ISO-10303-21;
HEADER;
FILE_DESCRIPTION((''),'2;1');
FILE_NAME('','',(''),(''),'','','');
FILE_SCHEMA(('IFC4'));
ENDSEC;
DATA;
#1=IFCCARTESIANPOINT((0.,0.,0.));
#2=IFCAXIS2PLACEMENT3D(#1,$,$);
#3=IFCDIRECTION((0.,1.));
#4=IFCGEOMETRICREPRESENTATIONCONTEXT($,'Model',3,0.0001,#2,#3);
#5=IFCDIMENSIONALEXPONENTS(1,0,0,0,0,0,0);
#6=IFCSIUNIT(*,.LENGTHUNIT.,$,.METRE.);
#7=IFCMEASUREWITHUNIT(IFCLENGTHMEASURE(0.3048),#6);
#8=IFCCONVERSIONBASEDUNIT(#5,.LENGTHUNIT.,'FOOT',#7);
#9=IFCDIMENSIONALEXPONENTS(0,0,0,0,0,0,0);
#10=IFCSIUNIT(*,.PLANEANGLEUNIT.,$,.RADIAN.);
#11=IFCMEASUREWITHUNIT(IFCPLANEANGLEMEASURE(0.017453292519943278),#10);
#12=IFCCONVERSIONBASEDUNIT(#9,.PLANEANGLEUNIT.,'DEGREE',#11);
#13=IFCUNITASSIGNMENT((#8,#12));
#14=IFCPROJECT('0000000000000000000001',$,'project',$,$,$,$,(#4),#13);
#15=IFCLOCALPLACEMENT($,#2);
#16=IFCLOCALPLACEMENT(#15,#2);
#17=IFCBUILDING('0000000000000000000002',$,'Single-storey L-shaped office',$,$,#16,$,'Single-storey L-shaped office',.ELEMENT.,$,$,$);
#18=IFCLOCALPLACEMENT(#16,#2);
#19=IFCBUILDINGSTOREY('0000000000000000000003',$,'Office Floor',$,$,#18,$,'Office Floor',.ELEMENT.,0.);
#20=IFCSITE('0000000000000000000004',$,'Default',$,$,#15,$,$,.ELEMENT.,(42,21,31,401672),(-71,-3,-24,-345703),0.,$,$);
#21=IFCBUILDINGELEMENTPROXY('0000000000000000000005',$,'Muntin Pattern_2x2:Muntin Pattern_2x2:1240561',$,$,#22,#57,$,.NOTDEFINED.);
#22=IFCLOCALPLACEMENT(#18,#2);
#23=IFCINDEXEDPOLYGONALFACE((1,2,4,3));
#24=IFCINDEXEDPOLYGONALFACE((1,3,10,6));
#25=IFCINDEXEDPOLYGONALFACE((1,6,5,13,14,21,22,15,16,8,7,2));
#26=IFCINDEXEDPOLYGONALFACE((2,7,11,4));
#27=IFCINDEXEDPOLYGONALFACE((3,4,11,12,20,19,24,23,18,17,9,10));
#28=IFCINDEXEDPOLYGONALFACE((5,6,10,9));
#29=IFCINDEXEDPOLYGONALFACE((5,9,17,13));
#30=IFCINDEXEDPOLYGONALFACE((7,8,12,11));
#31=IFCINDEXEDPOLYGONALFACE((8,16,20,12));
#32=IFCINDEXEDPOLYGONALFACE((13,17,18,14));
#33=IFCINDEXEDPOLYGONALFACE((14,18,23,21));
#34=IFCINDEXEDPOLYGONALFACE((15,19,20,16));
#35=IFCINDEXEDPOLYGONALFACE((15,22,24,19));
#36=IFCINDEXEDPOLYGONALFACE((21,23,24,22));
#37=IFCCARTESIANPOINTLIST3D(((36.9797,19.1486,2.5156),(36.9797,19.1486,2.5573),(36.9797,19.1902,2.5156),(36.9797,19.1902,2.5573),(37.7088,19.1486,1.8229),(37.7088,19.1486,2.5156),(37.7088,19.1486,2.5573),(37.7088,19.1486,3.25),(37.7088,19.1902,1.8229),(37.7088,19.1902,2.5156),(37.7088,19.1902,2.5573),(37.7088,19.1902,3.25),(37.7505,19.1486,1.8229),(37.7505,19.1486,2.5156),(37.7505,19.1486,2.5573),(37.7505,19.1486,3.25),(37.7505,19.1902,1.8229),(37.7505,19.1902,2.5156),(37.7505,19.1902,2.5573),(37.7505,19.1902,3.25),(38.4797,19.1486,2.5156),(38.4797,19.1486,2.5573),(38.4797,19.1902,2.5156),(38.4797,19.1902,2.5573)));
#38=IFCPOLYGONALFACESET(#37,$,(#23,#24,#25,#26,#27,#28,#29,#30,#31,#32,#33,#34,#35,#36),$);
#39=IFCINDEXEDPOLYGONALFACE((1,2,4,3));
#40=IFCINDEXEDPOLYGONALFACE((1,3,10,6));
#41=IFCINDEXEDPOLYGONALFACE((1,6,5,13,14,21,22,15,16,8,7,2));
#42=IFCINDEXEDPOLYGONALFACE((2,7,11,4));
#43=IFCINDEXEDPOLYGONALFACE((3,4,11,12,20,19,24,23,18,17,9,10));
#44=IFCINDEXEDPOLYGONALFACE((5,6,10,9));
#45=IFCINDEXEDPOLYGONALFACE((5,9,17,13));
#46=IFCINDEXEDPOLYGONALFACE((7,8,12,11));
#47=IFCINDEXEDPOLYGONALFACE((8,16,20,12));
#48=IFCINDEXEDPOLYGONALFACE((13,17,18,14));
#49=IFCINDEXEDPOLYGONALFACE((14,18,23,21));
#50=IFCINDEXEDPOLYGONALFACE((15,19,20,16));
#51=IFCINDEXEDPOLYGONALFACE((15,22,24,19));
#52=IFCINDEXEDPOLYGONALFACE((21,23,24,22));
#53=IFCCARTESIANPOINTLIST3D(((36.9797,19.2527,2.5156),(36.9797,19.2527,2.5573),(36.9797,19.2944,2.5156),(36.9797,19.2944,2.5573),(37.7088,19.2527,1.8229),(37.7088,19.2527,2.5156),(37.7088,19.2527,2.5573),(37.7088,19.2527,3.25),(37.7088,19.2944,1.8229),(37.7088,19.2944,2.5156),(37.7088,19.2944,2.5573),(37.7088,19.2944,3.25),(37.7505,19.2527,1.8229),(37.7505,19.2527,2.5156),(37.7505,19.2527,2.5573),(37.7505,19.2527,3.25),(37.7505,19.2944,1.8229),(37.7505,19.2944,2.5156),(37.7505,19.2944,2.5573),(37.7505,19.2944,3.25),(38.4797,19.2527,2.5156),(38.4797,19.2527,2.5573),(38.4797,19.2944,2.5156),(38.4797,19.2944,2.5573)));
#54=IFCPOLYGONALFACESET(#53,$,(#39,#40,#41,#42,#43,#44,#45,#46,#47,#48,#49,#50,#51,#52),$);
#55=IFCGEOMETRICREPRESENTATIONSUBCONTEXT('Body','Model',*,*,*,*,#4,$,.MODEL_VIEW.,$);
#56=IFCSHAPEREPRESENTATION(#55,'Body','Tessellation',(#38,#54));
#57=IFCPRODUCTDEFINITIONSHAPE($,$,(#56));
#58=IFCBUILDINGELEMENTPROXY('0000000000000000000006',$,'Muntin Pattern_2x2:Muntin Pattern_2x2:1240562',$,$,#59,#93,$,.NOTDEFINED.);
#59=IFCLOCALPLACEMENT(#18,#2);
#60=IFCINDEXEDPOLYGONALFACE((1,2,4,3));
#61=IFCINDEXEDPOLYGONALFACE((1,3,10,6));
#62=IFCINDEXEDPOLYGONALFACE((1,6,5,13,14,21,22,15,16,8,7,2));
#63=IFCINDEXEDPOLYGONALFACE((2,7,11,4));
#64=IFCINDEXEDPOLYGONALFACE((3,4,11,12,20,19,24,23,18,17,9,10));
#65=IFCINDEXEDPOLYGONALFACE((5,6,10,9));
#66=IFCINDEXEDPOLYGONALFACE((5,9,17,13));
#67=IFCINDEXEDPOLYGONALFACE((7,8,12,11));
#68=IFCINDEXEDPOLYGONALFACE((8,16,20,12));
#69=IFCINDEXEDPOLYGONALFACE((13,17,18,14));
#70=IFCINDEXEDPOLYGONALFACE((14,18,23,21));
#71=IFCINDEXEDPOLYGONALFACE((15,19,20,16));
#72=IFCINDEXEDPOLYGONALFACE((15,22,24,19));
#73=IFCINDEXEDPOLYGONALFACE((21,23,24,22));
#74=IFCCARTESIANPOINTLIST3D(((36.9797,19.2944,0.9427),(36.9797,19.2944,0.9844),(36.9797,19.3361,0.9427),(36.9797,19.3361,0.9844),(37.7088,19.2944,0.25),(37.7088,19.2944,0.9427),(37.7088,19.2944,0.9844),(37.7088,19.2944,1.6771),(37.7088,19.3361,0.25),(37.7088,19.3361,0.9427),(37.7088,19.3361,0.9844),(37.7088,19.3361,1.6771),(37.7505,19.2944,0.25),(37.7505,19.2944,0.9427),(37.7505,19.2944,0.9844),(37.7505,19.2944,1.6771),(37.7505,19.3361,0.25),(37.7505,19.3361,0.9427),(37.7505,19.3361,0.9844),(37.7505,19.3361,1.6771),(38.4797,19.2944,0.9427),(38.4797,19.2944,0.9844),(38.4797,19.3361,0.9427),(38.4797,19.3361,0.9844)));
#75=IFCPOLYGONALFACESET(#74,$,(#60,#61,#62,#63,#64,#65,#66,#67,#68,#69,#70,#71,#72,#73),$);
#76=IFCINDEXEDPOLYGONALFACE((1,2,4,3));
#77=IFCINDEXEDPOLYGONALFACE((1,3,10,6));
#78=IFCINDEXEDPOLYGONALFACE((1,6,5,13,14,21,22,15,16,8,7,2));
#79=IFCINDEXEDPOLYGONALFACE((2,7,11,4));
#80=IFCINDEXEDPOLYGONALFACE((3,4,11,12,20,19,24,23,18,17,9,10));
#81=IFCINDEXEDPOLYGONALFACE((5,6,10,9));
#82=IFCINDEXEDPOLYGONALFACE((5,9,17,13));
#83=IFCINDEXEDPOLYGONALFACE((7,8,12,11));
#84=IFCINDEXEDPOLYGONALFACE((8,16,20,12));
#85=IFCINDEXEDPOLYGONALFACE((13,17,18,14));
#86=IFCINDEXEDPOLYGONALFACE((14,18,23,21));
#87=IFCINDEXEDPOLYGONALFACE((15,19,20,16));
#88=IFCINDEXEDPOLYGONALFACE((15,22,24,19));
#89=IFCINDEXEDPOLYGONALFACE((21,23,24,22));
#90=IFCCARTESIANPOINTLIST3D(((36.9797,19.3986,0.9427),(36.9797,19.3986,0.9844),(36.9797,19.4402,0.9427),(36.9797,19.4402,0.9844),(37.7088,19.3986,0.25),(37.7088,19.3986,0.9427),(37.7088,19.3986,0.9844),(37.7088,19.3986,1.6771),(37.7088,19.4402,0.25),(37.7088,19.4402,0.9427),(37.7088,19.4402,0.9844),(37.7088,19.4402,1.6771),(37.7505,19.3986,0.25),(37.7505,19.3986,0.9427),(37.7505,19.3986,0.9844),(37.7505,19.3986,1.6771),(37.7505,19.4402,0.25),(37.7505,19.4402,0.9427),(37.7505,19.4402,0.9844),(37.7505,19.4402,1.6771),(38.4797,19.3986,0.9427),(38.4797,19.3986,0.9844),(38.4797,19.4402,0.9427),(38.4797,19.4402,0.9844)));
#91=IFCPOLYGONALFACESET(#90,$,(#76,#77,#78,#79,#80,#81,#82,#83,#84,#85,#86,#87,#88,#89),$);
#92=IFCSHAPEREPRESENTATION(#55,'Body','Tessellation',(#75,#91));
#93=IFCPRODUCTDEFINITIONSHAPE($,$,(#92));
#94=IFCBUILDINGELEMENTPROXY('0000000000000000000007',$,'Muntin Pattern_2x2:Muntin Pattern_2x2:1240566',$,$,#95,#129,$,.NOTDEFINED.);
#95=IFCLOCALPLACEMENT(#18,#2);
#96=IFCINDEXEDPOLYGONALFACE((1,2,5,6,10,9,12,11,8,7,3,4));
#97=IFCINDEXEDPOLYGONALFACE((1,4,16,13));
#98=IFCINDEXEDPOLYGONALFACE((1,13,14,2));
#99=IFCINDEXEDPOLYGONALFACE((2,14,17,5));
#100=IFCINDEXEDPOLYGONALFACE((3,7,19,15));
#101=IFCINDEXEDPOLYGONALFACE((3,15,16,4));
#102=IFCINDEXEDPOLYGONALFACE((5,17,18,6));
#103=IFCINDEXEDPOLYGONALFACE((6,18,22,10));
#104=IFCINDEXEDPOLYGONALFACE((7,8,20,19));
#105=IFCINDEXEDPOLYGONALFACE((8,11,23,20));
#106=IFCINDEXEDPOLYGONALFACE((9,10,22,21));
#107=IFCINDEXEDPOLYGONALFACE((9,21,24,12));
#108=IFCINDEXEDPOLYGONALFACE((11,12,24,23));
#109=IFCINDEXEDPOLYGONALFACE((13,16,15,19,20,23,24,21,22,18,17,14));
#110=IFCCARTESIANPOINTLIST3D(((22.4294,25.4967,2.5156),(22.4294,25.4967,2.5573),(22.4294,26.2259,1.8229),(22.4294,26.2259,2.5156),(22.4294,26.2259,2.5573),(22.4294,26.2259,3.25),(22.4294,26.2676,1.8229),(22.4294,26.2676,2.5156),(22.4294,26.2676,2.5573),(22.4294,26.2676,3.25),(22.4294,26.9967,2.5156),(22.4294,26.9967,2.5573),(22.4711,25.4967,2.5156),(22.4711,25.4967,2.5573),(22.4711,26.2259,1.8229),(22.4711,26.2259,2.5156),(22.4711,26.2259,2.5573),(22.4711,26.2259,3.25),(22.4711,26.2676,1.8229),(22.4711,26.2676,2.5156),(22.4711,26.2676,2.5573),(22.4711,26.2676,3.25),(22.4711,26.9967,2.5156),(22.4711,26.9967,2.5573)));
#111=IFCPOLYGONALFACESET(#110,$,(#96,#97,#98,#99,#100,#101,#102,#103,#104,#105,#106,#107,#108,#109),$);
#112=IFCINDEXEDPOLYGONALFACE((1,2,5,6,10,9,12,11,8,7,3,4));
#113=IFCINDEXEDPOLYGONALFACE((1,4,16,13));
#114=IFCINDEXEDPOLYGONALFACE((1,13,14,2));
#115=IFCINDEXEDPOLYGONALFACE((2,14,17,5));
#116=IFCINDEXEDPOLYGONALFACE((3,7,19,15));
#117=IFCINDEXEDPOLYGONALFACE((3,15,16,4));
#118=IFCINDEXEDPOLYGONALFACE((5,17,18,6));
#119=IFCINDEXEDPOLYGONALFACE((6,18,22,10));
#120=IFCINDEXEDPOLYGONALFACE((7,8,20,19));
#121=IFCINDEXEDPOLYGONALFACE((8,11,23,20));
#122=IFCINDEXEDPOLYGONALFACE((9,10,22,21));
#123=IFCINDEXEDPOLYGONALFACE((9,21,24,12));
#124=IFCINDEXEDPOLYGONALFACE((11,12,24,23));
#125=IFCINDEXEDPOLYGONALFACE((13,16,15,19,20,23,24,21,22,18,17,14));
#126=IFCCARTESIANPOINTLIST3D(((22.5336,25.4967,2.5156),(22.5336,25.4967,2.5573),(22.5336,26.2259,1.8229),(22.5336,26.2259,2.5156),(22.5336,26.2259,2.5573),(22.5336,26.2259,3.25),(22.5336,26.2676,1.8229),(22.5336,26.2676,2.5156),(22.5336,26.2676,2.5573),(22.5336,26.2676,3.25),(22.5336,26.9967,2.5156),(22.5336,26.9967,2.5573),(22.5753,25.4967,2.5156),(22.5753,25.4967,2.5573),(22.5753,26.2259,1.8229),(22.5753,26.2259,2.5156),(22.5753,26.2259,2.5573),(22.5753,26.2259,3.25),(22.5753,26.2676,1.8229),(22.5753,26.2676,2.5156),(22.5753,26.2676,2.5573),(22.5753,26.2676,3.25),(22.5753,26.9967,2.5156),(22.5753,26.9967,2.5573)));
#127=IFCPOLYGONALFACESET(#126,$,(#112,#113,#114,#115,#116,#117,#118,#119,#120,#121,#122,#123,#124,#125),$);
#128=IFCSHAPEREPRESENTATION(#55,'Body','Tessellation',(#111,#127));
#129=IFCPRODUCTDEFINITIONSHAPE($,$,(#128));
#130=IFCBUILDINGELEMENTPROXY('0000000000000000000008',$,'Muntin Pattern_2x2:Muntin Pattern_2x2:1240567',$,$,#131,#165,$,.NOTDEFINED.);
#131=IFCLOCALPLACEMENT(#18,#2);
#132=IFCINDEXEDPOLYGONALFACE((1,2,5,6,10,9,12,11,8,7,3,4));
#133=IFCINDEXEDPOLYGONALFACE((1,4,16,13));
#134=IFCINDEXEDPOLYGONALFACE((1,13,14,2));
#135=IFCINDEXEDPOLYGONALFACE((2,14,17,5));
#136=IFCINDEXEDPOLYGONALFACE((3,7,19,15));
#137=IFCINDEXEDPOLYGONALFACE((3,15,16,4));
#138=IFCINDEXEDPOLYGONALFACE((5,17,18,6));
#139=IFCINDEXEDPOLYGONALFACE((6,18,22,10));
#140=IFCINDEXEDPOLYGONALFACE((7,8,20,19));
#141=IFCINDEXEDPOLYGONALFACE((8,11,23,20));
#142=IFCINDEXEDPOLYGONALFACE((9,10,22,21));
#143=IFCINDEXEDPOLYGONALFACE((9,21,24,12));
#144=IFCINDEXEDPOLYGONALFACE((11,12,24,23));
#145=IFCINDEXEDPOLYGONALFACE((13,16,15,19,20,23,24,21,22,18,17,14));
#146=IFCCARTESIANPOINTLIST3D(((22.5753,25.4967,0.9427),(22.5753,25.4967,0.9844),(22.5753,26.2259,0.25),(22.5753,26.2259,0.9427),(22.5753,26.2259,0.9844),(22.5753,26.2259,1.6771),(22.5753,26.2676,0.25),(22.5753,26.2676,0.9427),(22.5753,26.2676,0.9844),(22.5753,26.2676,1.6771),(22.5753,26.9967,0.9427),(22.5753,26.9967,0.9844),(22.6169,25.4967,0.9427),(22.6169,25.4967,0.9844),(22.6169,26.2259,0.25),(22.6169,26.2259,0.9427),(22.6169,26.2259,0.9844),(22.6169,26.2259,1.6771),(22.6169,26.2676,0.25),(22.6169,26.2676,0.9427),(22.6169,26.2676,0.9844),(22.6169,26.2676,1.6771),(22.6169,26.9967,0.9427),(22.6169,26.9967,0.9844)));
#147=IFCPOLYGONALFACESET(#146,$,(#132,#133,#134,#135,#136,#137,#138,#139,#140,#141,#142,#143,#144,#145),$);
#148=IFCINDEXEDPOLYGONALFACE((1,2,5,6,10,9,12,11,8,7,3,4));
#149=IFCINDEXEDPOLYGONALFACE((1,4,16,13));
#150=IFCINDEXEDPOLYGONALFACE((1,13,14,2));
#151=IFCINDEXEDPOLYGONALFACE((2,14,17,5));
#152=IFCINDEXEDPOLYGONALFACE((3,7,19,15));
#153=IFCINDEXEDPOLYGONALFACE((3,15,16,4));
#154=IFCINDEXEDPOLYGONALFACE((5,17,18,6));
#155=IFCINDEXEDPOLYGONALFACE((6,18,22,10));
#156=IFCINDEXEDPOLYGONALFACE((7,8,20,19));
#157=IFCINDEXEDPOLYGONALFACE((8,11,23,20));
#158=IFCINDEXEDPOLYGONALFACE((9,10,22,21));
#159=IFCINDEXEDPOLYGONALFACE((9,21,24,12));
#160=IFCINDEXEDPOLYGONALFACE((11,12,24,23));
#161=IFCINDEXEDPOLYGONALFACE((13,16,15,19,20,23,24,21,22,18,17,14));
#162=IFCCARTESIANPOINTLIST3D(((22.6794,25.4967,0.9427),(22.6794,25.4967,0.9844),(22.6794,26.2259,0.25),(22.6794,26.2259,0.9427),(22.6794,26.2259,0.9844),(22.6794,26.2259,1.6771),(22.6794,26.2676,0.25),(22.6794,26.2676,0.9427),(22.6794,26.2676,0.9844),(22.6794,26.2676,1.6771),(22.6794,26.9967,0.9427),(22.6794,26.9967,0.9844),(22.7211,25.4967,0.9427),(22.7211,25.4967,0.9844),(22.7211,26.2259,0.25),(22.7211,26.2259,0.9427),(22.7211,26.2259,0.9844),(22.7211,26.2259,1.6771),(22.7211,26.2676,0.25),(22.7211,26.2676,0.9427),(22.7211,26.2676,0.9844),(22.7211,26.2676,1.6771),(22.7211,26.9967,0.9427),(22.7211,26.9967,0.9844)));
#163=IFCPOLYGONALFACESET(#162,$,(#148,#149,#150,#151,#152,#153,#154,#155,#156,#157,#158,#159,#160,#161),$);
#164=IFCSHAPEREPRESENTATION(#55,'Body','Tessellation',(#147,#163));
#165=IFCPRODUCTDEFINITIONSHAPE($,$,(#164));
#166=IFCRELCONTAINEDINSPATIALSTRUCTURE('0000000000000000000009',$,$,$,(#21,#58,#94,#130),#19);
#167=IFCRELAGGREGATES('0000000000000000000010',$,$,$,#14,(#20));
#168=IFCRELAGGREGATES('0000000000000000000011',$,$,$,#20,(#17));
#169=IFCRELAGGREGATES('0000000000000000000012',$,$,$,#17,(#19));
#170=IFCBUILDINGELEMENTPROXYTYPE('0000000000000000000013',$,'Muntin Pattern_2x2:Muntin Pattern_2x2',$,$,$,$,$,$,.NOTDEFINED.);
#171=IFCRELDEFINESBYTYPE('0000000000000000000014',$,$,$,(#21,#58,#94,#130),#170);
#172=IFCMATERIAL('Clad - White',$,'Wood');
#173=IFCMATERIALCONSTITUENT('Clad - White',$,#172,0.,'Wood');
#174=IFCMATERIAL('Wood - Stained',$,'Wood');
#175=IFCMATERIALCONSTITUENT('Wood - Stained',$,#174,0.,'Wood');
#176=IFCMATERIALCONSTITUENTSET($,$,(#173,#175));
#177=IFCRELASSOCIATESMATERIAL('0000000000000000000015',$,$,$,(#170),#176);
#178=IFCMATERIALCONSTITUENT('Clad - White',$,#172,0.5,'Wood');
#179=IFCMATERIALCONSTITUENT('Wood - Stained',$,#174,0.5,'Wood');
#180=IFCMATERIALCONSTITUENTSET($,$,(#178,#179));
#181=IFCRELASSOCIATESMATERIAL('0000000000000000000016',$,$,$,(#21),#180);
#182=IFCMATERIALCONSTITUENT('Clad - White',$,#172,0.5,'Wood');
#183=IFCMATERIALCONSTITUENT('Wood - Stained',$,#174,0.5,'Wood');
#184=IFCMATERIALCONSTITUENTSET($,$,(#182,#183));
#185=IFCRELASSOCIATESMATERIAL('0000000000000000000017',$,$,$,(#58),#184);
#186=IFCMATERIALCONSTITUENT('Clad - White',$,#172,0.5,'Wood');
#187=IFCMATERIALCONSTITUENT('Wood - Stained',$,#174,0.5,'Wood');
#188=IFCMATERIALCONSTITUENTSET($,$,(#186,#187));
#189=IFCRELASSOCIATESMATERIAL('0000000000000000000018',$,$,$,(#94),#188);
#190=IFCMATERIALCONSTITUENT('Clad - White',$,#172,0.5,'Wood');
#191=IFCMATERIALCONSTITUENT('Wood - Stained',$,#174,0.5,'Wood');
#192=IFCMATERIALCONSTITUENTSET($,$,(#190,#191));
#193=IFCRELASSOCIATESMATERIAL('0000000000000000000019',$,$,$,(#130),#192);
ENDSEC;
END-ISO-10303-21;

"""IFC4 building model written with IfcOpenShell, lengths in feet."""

from ifc_helpers import new_model, entity, si_unit, converted_unit, direction, frame, origin, place, context, subcontext, project, spatial, indexed_curve, outline, extrude, source, transform, mapped, material, constituent, constituent_set, type_object, type_shapes, element, save


model = new_model("IFC4")

# Units and contexts
model_context = context("Model", 3, precision=0.0001, world=origin(), true_north=direction((0.0, 1.0)))
body_context = subcontext(model_context, "Body", "Model", "MODEL_VIEW")
ifc_project = project(units=[converted_unit("LENGTHUNIT", "FOOT", entity("IfcLengthMeasure", 0.3048), si_unit("LENGTHUNIT", "METRE"), dimensions=[1, 0, 0, 0, 0, 0, 0]), converted_unit("PLANEANGLEUNIT", "DEGREE", entity("IfcPlaneAngleMeasure", 0.017453292519943278), si_unit("PLANEANGLEUNIT", "RADIAN"), dimensions=[0, 0, 0, 0, 0, 0, 0])], contexts=[model_context])

# Site, building, storey
site_placement = place(None, origin())
site = spatial("IfcSite", under=ifc_project, at=site_placement, Name="Default", CompositionType="ELEMENT", RefLatitude=(42, 21, 31, 401672), RefLongitude=(-71, -3, -24, -345703), RefElevation=0.0)
building_placement = place(site_placement, origin())
building = spatial("IfcBuilding", under=site, at=building_placement, Name="Single-storey L-shaped office", LongName="Single-storey L-shaped office", CompositionType="ELEMENT")
storey_placement = place(building_placement, origin())
storey = spatial("IfcBuildingStorey", under=building, at=storey_placement, Name="Office Floor", LongName="Office Floor", CompositionType="ELEMENT", Elevation=0.0)

# Shared definitions
ifc_material_1 = material(Name="Wood - Stained", Category="Wood")

# Building element proxies
ifc_material_2 = material(Name="Clad - White", Category="Wood")
ifc_constituent_1 = constituent(ifc_material_2, Name="Clad - White", Category="Wood", fraction=0.0)
ifc_constituent_2 = constituent(ifc_material_1, Name="Wood - Stained", Category="Wood", fraction=0.0)
ifc_constituent_set_1 = constituent_set(constituents=[ifc_constituent_1, ifc_constituent_2])
building_element_proxy_type_1 = type_object("IfcBuildingElementProxyType", Name="Muntin Pattern_2x2:Muntin Pattern_2x2", PredefinedType="NOTDEFINED", material=ifc_constituent_set_1)
shared_shape_1 = source(origin(), body_context, "Body", "SweptSolid", [
    extrude(outline(indexed_curve([(0.0208, -0.0208), (0.7135, -0.0208), (0.7135, 0.0208), (0.0208, 0.0208), (0.0208, 0.75), (-0.0208, 0.75), (-0.0208, 0.0208), (-0.7135, 0.0208), (-0.7135, -0.0208), (-0.0208, -0.0208), (-0.0208, -0.75), (0.0208, -0.75), (0.0208, -0.0208)], self_intersect=False)), frame((0.0, 0.0312, 0.7135), z_axis=(0.0, 1.0, 0.0), x_axis=(0.0, 0.0, 1.0)), (0.0, 0.0, 1.0), 0.0417),
    extrude(outline(indexed_curve([(0.0208, -0.0208), (0.7135, -0.0208), (0.7135, 0.0208), (0.0208, 0.0208), (0.0208, 0.75), (-0.0208, 0.75), (-0.0208, 0.0208), (-0.7135, 0.0208), (-0.7135, -0.0208), (-0.0208, -0.0208), (-0.0208, -0.75), (0.0208, -0.75), (0.0208, -0.0208)], self_intersect=False)), frame((0.0, -0.0729, 0.7135), z_axis=(0.0, 1.0, 0.0), x_axis=(0.0, 0.0, 1.0)), (0.0, 0.0, 1.0), 0.0417),
])
type_shapes(building_element_proxy_type_1, [shared_shape_1])
ifc_constituent_3 = constituent(ifc_material_2, Name="Clad - White", Category="Wood", fraction=0.5)
ifc_constituent_4 = constituent(ifc_material_1, Name="Wood - Stained", Category="Wood", fraction=0.5)
ifc_constituent_set_2 = constituent_set(constituents=[ifc_constituent_3, ifc_constituent_4])
proxy_1_placement = place(storey_placement, frame((37.7297, 19.2215, 1.8229), z_axis=(0.0, 0.0, 1.0), x_axis=(-1.0, 0.0, 0.0)))
element("IfcBuildingElementProxy", 1, at=proxy_1_placement, inside=storey, type_object=building_element_proxy_type_1, material=ifc_constituent_set_2, Name="Muntin Pattern_2x2:Muntin Pattern_2x2:1240561", PredefinedType="NOTDEFINED", context=body_context, shape_type="MappedRepresentation", body=[
    mapped(shared_shape_1, transform((0.0, 0.0, 0.0), scale=1.0)),
])
ifc_constituent_5 = constituent(ifc_material_2, Name="Clad - White", Category="Wood", fraction=0.5)
ifc_constituent_6 = constituent(ifc_material_1, Name="Wood - Stained", Category="Wood", fraction=0.5)
ifc_constituent_set_3 = constituent_set(constituents=[ifc_constituent_5, ifc_constituent_6])
proxy_2_placement = place(storey_placement, frame((37.7297, 19.3673, 0.25), z_axis=(0.0, 0.0, 1.0), x_axis=(-1.0, 0.0, 0.0)))
element("IfcBuildingElementProxy", 2, at=proxy_2_placement, inside=storey, type_object=building_element_proxy_type_1, material=ifc_constituent_set_3, Name="Muntin Pattern_2x2:Muntin Pattern_2x2:1240562", PredefinedType="NOTDEFINED", context=body_context, shape_type="MappedRepresentation", body=[
    mapped(shared_shape_1, transform((0.0, 0.0, 0.0), scale=1.0)),
])
ifc_constituent_7 = constituent(ifc_material_2, Name="Clad - White", Category="Wood", fraction=0.5)
ifc_constituent_8 = constituent(ifc_material_1, Name="Wood - Stained", Category="Wood", fraction=0.5)
ifc_constituent_set_4 = constituent_set(constituents=[ifc_constituent_7, ifc_constituent_8])
proxy_3_placement = place(storey_placement, frame((22.5023, 26.2467, 1.8229), z_axis=(0.0, 0.0, 1.0), x_axis=(0.0, 1.0, 0.0)))
element("IfcBuildingElementProxy", 3, at=proxy_3_placement, inside=storey, type_object=building_element_proxy_type_1, material=ifc_constituent_set_4, Name="Muntin Pattern_2x2:Muntin Pattern_2x2:1240566", PredefinedType="NOTDEFINED", context=body_context, shape_type="MappedRepresentation", body=[
    mapped(shared_shape_1, transform((0.0, 0.0, 0.0), scale=1.0)),
])
ifc_constituent_9 = constituent(ifc_material_2, Name="Clad - White", Category="Wood", fraction=0.5)
ifc_constituent_10 = constituent(ifc_material_1, Name="Wood - Stained", Category="Wood", fraction=0.5)
ifc_constituent_set_5 = constituent_set(constituents=[ifc_constituent_9, ifc_constituent_10])
proxy_4_placement = place(storey_placement, frame((22.6482, 26.2467, 0.25), z_axis=(0.0, 0.0, 1.0), x_axis=(0.0, 1.0, 0.0)))
element("IfcBuildingElementProxy", 4, at=proxy_4_placement, inside=storey, type_object=building_element_proxy_type_1, material=ifc_constituent_set_5, Name="Muntin Pattern_2x2:Muntin Pattern_2x2:1240567", PredefinedType="NOTDEFINED", context=body_context, shape_type="MappedRepresentation", body=[
    mapped(shared_shape_1, transform((0.0, 0.0, 0.0), scale=1.0)),
])

save(model, "model.ifc")
